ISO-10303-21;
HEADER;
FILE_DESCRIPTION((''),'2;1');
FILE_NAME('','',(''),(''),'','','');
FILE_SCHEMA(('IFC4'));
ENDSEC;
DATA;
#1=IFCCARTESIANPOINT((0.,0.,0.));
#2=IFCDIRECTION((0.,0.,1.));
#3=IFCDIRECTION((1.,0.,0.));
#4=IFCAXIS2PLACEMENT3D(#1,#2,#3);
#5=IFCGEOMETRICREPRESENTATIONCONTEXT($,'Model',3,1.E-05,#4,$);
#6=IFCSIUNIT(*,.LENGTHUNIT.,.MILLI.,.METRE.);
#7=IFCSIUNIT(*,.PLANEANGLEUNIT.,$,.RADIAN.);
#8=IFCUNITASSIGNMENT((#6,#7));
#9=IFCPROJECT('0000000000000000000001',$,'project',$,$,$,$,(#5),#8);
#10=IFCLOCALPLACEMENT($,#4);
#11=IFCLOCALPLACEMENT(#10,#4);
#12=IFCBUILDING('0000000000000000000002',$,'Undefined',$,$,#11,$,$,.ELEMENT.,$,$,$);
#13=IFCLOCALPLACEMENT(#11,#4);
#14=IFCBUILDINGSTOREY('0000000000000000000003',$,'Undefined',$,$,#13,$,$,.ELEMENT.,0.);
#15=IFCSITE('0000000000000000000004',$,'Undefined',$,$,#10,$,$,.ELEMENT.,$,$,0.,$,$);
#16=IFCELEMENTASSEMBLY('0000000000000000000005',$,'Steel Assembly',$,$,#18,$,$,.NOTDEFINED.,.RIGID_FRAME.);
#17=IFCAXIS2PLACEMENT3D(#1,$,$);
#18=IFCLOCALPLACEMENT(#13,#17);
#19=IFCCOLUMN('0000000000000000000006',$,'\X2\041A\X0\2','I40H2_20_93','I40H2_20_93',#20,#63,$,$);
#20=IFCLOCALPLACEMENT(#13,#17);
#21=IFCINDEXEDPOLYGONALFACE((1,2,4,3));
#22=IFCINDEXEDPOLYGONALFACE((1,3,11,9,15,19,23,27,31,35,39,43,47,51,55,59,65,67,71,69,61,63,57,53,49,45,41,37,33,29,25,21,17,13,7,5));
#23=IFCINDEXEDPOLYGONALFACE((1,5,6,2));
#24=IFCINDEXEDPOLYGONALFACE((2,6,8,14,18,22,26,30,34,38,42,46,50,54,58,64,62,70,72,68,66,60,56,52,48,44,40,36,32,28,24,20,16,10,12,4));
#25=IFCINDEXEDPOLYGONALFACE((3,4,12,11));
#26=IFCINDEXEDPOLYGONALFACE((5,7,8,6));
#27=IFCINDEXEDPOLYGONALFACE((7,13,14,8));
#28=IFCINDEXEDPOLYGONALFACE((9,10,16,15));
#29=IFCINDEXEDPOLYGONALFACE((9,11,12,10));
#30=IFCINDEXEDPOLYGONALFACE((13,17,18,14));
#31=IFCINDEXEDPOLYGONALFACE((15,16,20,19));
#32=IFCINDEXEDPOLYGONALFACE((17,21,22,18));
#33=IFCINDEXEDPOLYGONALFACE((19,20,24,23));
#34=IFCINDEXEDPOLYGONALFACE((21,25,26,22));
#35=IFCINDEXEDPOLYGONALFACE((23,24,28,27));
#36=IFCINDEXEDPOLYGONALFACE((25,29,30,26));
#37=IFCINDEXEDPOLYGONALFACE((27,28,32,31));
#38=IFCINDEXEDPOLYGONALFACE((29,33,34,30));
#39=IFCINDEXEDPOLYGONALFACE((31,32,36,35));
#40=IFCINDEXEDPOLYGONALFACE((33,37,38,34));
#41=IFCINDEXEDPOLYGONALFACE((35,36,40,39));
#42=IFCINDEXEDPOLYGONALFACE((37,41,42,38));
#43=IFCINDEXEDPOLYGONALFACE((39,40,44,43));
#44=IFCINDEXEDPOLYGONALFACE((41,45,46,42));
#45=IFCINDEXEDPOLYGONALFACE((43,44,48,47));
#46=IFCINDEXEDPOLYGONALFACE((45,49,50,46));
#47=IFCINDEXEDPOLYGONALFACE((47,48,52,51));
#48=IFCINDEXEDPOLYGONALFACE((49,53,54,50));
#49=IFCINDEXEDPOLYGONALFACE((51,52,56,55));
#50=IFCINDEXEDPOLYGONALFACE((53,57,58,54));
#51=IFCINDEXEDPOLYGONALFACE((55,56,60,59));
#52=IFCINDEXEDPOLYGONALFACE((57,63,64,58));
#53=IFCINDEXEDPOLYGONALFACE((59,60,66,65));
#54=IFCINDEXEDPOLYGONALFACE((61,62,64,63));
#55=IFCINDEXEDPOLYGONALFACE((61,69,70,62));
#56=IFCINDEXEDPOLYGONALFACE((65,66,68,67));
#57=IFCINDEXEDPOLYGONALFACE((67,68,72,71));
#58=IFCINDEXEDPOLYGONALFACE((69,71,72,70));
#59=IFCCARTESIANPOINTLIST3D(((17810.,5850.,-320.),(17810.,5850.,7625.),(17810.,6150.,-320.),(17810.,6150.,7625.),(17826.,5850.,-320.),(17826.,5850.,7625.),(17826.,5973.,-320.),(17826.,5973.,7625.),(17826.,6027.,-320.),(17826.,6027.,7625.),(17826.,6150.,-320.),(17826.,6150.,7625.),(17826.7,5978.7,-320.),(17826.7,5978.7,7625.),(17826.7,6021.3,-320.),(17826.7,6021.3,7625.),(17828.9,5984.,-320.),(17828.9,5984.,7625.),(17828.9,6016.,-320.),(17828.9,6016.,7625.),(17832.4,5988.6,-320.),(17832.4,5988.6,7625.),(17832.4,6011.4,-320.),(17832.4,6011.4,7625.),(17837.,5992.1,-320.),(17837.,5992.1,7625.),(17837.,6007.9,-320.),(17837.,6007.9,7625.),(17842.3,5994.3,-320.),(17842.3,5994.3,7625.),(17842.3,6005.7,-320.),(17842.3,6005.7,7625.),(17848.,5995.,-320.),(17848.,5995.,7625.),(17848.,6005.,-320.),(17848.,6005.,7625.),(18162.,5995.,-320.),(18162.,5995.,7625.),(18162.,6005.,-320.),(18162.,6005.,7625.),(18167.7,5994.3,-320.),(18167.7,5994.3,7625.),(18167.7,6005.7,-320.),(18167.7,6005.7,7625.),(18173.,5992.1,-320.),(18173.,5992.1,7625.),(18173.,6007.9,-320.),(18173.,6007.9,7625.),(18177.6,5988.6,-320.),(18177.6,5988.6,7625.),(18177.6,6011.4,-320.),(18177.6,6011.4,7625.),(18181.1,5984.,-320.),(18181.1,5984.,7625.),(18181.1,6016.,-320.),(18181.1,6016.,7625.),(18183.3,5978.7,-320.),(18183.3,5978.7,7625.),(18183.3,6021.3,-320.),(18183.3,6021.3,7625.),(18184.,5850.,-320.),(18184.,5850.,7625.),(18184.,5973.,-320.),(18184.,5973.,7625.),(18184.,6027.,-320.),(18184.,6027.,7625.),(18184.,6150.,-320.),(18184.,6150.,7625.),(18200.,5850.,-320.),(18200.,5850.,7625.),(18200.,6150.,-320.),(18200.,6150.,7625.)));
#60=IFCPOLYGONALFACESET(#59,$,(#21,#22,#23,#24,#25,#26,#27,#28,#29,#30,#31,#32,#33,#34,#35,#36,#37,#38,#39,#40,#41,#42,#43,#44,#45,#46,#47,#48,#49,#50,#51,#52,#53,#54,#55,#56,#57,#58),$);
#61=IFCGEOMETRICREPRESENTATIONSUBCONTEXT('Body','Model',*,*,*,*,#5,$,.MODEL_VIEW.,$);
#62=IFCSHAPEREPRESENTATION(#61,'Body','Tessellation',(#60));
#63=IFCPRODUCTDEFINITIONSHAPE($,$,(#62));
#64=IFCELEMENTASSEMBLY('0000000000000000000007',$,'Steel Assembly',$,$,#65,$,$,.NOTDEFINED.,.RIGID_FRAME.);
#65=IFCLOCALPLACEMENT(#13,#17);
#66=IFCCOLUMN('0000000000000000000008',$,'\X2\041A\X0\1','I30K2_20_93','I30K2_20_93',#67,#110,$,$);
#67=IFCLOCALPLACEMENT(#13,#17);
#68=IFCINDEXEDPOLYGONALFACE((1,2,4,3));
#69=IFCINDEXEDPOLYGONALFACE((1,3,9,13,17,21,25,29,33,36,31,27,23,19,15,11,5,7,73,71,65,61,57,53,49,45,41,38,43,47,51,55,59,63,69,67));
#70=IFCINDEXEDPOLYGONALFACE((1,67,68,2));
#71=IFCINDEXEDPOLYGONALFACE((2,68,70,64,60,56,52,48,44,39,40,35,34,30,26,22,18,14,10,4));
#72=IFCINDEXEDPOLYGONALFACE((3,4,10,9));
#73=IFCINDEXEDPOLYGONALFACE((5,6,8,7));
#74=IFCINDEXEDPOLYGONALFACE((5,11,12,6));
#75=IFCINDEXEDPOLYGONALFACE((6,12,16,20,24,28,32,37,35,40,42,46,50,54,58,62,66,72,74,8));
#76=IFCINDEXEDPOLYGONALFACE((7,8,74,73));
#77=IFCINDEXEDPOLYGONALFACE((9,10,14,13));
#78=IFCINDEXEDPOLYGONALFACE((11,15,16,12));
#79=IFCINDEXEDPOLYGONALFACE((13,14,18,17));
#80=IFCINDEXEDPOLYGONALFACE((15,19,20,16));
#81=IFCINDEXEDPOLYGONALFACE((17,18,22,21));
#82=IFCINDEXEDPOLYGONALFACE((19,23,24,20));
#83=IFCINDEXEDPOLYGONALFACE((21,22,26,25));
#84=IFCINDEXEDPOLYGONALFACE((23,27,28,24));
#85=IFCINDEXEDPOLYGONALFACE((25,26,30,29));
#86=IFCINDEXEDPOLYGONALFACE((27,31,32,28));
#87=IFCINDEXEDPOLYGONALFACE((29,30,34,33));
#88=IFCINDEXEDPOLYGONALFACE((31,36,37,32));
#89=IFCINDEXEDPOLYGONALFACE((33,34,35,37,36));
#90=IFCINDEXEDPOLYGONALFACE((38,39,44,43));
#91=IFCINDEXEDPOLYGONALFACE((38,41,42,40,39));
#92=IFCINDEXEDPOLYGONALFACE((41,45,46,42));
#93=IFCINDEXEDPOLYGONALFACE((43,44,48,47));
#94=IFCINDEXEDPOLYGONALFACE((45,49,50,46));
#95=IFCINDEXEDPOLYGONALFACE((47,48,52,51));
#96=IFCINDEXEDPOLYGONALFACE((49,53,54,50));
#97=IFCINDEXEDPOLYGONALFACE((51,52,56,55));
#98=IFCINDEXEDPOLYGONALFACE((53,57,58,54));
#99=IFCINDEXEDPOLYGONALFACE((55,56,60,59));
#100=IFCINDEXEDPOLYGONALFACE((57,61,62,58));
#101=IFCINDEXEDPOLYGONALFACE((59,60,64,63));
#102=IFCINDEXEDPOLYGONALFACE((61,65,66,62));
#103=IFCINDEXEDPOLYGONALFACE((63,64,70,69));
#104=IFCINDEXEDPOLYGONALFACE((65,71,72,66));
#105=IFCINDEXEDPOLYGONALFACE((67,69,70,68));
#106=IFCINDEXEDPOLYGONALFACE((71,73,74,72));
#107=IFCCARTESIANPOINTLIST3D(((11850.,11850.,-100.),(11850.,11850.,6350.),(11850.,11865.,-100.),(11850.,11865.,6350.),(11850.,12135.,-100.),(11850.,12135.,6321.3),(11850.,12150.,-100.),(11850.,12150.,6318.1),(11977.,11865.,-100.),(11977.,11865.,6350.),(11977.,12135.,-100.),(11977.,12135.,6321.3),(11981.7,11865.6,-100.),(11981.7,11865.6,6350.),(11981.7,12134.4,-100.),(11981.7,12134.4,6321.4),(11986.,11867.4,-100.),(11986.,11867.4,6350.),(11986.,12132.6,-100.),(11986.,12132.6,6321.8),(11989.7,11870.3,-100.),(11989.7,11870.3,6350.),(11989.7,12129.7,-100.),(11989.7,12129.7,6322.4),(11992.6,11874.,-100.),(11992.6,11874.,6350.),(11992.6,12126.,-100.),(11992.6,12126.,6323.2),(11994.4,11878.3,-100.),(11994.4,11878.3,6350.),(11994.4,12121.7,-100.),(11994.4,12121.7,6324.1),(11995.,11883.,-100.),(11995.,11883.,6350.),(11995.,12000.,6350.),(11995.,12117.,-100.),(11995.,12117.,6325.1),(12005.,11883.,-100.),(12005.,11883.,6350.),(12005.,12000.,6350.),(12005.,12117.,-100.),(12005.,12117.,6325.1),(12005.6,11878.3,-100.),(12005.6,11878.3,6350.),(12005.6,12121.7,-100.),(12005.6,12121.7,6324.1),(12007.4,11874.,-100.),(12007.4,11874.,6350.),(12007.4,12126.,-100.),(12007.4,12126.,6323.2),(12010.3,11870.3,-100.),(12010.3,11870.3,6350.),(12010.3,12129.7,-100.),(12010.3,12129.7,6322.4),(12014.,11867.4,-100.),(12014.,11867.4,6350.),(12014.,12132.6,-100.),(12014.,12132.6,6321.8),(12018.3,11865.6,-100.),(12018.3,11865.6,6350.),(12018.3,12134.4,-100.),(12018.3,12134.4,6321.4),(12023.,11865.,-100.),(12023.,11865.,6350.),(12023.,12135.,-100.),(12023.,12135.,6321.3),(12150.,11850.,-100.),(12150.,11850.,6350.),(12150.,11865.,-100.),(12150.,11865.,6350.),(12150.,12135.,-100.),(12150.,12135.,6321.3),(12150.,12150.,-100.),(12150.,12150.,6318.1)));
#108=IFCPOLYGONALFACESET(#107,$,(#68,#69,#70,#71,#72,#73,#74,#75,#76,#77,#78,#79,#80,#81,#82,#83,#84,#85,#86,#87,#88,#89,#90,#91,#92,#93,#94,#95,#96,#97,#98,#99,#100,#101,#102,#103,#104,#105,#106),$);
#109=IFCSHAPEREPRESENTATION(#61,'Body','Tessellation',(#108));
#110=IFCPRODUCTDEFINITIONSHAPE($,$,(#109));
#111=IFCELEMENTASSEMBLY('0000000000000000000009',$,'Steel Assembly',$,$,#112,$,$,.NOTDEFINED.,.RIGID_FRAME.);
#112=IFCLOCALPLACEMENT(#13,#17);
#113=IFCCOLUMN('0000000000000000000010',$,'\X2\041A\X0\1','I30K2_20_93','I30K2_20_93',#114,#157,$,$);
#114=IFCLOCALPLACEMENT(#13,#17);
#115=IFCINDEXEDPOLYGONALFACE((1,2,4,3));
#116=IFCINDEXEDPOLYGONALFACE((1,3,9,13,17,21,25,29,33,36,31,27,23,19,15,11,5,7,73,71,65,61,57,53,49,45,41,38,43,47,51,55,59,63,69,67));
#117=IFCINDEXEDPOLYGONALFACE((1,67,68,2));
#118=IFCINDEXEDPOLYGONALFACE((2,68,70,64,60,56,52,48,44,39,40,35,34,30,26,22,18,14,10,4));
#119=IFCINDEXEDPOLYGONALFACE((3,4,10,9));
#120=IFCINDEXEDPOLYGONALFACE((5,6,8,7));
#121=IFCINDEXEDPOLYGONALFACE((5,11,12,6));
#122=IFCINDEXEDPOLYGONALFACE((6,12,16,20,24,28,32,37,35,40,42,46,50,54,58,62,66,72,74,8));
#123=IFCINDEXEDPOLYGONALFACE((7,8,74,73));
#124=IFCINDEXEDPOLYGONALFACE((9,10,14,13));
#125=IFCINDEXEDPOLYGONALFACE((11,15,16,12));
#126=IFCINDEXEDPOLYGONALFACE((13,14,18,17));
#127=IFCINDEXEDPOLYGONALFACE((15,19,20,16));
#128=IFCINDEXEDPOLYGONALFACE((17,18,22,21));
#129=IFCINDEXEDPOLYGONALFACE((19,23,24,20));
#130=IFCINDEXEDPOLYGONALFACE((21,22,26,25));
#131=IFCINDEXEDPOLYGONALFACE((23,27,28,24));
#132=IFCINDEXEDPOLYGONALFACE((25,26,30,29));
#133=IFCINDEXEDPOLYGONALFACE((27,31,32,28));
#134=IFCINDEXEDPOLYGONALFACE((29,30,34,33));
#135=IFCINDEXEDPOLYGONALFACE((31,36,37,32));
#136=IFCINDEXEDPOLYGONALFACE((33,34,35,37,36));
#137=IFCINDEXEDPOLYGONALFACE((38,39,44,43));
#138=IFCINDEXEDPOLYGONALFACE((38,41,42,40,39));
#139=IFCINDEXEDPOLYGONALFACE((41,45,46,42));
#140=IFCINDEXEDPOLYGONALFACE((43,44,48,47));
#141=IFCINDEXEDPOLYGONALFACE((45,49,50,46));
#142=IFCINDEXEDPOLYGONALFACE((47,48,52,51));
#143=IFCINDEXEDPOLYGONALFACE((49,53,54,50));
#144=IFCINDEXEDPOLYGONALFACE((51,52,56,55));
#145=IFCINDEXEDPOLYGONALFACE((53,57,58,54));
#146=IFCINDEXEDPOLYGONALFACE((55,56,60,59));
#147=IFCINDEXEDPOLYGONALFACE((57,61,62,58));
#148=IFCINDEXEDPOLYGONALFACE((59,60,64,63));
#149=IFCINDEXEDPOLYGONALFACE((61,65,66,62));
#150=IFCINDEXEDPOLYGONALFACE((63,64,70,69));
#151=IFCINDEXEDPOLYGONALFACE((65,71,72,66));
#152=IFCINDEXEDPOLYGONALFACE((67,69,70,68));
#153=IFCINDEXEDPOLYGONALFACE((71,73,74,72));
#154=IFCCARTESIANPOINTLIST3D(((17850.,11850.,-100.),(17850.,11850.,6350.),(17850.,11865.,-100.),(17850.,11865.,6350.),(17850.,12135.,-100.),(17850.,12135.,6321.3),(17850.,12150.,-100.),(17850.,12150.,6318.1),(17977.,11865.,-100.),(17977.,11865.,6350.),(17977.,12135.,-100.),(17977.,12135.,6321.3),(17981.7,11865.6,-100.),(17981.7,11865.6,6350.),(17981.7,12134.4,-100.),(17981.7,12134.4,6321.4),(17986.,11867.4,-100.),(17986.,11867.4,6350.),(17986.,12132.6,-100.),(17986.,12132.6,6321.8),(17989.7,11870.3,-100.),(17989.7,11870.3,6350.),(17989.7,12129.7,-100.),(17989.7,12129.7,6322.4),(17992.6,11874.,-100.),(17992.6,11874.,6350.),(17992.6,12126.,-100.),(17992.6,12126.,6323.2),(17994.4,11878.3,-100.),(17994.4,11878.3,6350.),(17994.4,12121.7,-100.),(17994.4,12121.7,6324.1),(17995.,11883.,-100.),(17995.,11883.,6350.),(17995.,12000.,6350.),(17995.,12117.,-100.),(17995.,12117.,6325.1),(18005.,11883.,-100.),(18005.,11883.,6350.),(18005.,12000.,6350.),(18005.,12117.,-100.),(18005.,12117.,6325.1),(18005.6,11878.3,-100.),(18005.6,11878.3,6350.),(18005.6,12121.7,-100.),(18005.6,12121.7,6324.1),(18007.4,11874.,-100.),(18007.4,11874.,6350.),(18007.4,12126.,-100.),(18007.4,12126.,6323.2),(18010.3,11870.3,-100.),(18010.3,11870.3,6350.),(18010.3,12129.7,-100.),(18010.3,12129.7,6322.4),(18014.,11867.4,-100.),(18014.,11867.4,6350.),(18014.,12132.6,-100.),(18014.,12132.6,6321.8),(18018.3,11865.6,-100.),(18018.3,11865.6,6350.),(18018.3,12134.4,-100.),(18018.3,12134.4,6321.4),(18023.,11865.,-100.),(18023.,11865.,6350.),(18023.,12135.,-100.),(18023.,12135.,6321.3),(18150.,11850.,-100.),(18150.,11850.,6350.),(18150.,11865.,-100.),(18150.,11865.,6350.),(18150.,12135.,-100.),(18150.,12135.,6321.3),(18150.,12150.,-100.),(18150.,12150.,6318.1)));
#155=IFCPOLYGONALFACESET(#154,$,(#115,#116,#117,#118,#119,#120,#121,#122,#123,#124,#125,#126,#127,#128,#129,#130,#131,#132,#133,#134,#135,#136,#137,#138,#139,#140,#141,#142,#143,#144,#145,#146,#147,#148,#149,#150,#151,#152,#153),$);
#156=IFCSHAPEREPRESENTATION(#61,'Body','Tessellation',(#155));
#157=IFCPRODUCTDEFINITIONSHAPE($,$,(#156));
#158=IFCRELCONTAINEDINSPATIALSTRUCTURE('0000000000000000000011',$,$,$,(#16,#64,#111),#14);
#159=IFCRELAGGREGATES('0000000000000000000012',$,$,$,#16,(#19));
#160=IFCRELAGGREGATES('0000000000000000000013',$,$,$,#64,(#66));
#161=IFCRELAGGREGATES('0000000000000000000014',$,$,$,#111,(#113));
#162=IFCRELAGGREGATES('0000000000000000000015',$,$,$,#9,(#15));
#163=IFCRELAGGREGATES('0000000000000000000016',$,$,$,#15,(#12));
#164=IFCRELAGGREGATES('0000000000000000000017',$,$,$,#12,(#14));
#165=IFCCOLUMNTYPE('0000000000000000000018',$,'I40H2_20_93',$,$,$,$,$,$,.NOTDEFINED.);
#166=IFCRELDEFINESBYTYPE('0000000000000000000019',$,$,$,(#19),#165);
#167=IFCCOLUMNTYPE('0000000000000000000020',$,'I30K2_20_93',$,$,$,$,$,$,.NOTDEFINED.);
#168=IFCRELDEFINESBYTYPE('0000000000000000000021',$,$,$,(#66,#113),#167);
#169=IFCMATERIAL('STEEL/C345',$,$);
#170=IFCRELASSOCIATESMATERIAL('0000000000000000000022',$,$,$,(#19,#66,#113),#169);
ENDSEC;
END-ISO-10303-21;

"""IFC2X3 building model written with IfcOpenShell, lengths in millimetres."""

from ifc_helpers import new_model, si_unit, frame, origin_with_axes, origin_2d_with_axis, place, context, subcontext, project, spatial, i_section, extrude, clip, halfspace, material, type_object, element, aggregate, save


model = new_model("IFC2X3")

# Units and contexts
model_context = context("Model", 3, precision=1e-05, world=origin_with_axes())
body_context = subcontext(model_context, "Body", "Model", "MODEL_VIEW")
ifc_project = project(units=[si_unit("LENGTHUNIT", "METRE", prefix="MILLI"), si_unit("PLANEANGLEUNIT", "RADIAN")], contexts=[model_context])

# Site, building, storey
site_placement = place(None, origin_with_axes())
site = spatial("IfcSite", under=ifc_project, at=site_placement, Name="Undefined", CompositionType="ELEMENT", RefElevation=0.0)
building_placement = place(site_placement, origin_with_axes())
building = spatial("IfcBuilding", under=site, at=building_placement, Name="Undefined", CompositionType="ELEMENT")
storey_placement = place(building_placement, origin_with_axes())
storey = spatial("IfcBuildingStorey", under=building, at=storey_placement, Name="Undefined", CompositionType="ELEMENT", Elevation=0.0)

# Element assemblies, columns
assembly_1_placement = place(storey_placement, origin_with_axes())
assembly_1 = element("IfcElementAssembly", 1, at=assembly_1_placement, inside=storey, Name="Steel Assembly", AssemblyPlace="NOTDEFINED", PredefinedType="RIGID_FRAME")
ifc_material_1 = material(Name="STEEL/C345")
column_type_1 = type_object("IfcColumnType", Name="I40H2_20_93", PredefinedType="NOTDEFINED")
column_1_placement = place(assembly_1_placement, frame((18005.0, 6000.0, -320.0), z_axis=(0.0, 0.0, 1.0), x_axis=(1.0, 0.0, 0.0)))
column_1 = element("IfcColumn", 2, at=column_1_placement, type_object=column_type_1, material=ifc_material_1, Name="К2", Description="I40H2_20_93", ObjectType="I40H2_20_93", context=body_context, shape_type="SweptSolid", body=[
    extrude(i_section(OverallWidth=300.0, OverallDepth=390.0, WebThickness=10.0, FlangeThickness=16.0, FilletRadius=22.0, at=origin_2d_with_axis()), frame((0.0, 0.0, 7945.0), z_axis=(0.0, 0.0, -1.0), x_axis=(0.0, 1.0, 0.0)), (0.0, 0.0, 1.0), 7945.0),
])
aggregate(assembly_1, [column_1])
assembly_2_placement = place(storey_placement, origin_with_axes())
assembly_2 = element("IfcElementAssembly", 3, at=assembly_2_placement, inside=storey, Name="Steel Assembly", AssemblyPlace="NOTDEFINED", PredefinedType="RIGID_FRAME")
column_type_2 = type_object("IfcColumnType", Name="I30K2_20_93", PredefinedType="NOTDEFINED")
column_2_placement = place(assembly_2_placement, frame((12000.0, 12000.0, -100.0), z_axis=(0.0, 0.0, 1.0), x_axis=(0.0, 1.0, 0.0)))
column_2 = element("IfcColumn", 4, at=column_2_placement, type_object=column_type_2, material=ifc_material_1, Name="К1", Description="I30K2_20_93", ObjectType="I30K2_20_93", context=body_context, shape_type="Clipping", body=[
    clip(extrude(i_section(OverallWidth=300.0, OverallDepth=300.0, WebThickness=10.0, FlangeThickness=15.0, FilletRadius=18.0, at=origin_2d_with_axis()), frame((0.0, 0.0, 6450.0), z_axis=(0.0, 0.0, -1.0), x_axis=(0.0, 1.0, 0.0)), (0.0, 0.0, 1.0), 6450.0), halfspace(frame((-150.0, 150.0, 6481.9), z_axis=(0.207859, 0.0, 0.978159), x_axis=(0.978159, 0.0, -0.207859)), False)),
])
aggregate(assembly_2, [column_2])
assembly_3_placement = place(storey_placement, origin_with_axes())
assembly_3 = element("IfcElementAssembly", 5, at=assembly_3_placement, inside=storey, Name="Steel Assembly", AssemblyPlace="NOTDEFINED", PredefinedType="RIGID_FRAME")
column_3_placement = place(assembly_3_placement, frame((18000.0, 12000.0, -100.0), z_axis=(0.0, 0.0, 1.0), x_axis=(0.0, 1.0, 0.0)))
column_3 = element("IfcColumn", 6, at=column_3_placement, type_object=column_type_2, material=ifc_material_1, Name="К1", Description="I30K2_20_93", ObjectType="I30K2_20_93", context=body_context, shape_type="Clipping", body=[
    clip(extrude(i_section(OverallWidth=300.0, OverallDepth=300.0, WebThickness=10.0, FlangeThickness=15.0, FilletRadius=18.0, at=origin_2d_with_axis()), frame((0.0, 0.0, 6450.0), z_axis=(0.0, 0.0, -1.0), x_axis=(0.0, 1.0, 0.0)), (0.0, 0.0, 1.0), 6450.0), halfspace(frame((-150.0, 150.0, 6481.9), z_axis=(0.207859, 0.0, 0.978159), x_axis=(0.978159, 0.0, -0.207859)), False)),
])
aggregate(assembly_3, [column_3])

save(model, "model.ifc")
